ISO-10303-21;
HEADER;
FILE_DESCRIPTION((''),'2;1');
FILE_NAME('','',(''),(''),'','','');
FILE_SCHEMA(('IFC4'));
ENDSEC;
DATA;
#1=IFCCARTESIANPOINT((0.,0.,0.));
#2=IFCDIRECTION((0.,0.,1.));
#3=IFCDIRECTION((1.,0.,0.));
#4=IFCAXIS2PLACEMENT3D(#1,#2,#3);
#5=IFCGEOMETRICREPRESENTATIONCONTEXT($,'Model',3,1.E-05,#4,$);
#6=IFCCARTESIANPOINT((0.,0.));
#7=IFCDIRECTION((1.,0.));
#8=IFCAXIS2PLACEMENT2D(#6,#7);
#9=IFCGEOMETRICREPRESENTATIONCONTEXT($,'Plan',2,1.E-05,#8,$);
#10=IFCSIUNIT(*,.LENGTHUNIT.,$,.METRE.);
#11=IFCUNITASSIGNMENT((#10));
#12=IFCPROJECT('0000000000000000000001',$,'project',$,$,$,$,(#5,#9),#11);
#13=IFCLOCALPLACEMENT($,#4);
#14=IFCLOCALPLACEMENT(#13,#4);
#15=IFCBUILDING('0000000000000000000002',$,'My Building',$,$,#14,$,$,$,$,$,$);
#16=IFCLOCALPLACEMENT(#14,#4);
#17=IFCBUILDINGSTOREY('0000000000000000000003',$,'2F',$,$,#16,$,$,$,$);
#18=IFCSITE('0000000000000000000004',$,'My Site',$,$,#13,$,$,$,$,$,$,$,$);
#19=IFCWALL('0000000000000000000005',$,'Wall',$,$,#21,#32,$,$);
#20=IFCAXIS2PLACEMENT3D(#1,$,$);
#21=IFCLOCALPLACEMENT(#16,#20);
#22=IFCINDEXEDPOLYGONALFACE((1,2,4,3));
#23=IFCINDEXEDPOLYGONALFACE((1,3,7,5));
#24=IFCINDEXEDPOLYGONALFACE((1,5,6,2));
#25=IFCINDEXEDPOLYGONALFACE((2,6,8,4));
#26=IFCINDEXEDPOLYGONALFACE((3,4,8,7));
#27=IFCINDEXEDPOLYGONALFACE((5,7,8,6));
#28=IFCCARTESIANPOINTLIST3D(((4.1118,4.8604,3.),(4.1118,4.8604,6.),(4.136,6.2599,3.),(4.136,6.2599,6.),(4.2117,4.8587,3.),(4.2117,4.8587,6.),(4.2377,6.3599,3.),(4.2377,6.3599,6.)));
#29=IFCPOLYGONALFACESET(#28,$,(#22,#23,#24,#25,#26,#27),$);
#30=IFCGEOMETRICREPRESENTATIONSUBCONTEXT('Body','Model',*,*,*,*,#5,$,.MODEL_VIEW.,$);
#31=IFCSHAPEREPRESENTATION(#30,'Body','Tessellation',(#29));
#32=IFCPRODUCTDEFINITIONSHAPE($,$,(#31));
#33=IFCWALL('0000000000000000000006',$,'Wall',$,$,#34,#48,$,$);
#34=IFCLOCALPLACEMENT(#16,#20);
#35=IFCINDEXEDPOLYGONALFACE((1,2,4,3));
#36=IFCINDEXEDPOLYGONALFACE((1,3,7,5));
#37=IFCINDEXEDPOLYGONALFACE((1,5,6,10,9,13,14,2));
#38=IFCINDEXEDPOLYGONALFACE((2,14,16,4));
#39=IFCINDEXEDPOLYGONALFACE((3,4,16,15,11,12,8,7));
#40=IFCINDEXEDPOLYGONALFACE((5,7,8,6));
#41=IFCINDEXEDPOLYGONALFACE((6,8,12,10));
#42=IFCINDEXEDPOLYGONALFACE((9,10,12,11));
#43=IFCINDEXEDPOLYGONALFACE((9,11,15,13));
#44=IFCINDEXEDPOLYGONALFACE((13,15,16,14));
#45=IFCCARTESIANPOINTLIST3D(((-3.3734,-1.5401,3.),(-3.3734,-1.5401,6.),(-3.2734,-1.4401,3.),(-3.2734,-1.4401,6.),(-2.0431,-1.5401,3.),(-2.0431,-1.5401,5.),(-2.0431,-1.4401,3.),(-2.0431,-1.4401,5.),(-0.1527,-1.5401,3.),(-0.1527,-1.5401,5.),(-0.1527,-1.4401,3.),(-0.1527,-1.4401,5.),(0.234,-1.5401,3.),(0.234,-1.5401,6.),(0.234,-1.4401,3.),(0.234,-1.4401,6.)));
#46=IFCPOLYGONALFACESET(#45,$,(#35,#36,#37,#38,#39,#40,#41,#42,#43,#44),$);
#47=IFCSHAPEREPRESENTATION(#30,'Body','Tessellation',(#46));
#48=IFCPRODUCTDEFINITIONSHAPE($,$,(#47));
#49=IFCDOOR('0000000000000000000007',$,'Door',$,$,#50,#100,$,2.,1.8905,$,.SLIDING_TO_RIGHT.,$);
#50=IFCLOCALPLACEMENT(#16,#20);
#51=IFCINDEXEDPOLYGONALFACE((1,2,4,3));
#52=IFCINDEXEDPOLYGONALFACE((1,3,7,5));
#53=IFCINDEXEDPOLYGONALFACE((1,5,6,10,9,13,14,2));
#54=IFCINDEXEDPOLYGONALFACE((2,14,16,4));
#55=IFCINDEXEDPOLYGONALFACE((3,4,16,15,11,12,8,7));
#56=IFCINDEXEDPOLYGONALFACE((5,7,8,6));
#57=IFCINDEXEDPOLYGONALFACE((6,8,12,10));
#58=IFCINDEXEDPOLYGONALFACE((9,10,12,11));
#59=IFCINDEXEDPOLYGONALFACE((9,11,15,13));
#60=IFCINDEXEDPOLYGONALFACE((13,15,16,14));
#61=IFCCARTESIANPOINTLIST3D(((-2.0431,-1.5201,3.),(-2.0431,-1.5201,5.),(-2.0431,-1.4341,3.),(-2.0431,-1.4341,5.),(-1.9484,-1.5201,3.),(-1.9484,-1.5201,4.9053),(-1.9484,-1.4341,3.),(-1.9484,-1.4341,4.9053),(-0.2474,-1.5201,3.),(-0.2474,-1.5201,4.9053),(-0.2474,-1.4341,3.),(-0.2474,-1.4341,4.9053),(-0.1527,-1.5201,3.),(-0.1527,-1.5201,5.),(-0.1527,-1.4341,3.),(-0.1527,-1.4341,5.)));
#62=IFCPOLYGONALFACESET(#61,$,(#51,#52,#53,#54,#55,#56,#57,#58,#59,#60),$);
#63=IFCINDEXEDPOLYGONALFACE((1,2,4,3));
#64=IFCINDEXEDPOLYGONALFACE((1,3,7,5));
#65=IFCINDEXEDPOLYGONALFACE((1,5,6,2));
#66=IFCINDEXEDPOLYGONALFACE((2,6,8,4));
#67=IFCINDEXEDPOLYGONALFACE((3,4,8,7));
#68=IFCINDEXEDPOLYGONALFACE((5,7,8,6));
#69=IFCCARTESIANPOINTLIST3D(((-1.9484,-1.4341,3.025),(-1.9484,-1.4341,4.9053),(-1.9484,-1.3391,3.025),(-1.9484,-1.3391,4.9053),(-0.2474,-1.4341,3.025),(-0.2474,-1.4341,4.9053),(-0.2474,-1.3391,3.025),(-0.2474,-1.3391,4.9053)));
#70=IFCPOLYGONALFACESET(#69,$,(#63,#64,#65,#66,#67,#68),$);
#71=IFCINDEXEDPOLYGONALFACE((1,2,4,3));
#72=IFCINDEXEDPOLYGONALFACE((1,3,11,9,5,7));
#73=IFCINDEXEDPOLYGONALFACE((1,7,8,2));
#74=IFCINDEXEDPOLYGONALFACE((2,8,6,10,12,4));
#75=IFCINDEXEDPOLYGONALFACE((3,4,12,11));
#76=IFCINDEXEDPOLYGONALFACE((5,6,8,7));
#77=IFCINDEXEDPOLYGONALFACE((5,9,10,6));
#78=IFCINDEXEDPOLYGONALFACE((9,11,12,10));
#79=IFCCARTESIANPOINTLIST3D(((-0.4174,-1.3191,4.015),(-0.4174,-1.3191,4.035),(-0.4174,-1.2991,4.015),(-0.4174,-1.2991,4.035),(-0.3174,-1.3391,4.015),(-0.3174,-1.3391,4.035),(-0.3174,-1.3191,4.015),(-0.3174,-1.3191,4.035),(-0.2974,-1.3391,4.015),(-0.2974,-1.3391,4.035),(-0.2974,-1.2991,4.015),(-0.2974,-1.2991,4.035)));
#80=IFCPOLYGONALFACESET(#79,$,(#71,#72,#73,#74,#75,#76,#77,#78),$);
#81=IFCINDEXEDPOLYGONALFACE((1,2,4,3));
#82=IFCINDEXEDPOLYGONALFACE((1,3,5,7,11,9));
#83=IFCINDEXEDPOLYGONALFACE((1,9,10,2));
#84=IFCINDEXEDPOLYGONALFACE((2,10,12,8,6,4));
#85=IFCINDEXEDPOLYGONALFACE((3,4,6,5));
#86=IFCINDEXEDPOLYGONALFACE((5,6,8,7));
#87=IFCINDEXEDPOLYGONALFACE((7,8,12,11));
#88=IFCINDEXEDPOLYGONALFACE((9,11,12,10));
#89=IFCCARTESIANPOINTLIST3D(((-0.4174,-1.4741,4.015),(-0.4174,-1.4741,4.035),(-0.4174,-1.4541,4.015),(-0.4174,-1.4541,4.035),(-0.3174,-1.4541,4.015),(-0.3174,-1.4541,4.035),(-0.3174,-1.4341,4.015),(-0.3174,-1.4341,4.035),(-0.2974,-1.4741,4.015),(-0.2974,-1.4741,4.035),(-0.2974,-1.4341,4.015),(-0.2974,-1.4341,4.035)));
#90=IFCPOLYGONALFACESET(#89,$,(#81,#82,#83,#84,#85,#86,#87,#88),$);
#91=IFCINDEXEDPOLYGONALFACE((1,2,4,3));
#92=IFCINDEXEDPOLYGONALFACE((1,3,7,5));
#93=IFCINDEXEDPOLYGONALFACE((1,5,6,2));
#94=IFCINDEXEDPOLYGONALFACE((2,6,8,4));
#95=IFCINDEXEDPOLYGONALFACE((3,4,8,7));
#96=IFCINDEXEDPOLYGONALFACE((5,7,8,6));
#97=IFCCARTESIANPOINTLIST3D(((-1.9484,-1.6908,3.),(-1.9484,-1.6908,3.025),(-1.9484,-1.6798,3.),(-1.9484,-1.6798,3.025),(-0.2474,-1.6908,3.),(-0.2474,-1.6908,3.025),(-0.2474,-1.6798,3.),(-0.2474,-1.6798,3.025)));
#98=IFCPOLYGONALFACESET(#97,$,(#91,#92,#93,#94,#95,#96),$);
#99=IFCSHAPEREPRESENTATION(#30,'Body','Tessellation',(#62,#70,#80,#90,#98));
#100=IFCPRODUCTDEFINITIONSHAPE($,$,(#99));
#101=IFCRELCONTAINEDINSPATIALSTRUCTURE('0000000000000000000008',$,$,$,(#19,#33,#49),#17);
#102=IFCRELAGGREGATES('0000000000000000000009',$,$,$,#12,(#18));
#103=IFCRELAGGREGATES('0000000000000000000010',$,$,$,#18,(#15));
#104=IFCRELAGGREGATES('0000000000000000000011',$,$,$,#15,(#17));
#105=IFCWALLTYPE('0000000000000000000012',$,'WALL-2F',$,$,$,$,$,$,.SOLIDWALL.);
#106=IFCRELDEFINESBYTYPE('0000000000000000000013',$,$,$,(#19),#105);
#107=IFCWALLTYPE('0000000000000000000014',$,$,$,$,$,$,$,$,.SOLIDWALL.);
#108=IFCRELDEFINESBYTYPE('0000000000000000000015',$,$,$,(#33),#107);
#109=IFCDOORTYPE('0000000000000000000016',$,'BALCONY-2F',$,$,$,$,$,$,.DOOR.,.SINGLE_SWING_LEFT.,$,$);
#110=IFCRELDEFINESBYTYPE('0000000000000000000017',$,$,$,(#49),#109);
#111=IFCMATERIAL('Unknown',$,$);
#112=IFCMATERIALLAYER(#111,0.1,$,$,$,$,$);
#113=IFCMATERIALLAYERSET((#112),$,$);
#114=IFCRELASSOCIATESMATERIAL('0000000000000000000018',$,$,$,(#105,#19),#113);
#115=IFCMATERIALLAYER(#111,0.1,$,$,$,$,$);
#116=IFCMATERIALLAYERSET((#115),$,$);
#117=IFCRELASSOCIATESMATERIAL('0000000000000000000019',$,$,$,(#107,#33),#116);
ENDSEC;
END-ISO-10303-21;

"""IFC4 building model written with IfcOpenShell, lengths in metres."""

from ifc_helpers import new_model, entity, si_unit, frame, origin_with_axes, origin_2d_with_axis, place, context, subcontext, project, spatial, line, indexed_curve, outline, extrude, shape, source, transform, mapped, material, layer, layer_set, layer_usage, type_object, type_shapes, element, fill, save


model = new_model("IFC4")

# Units and contexts
model_context = context("Model", 3, precision=1e-05, world=origin_with_axes())
plan_context = context("Plan", 2, precision=1e-05, world=origin_2d_with_axis())
body_context_1 = subcontext(model_context, "Body", "Model", "MODEL_VIEW")
body_context_2 = subcontext(plan_context, "Body", "Plan", "PLAN_VIEW")
ifc_project = project(units=[si_unit("LENGTHUNIT", "METRE")], contexts=[model_context, plan_context])

# Site, building, storey
site_placement = place(None, origin_with_axes())
site = spatial("IfcSite", under=ifc_project, at=site_placement, Name="My Site")
building_placement = place(site_placement, origin_with_axes())
building = spatial("IfcBuilding", under=site, at=building_placement, Name="My Building")
storey_placement = place(building_placement, origin_with_axes())
storey = spatial("IfcBuildingStorey", under=building, at=storey_placement, Name="2F")

# Shared definitions
ifc_material = material(Name="Unknown")

# Shared definitions
ifc_layer_1 = layer(ifc_material, 0.1)
ifc_layer_set_1 = layer_set([ifc_layer_1])
wall_type_1 = type_object("IfcWallType", Name="WALL-2F", PredefinedType="SOLIDWALL", material=ifc_layer_set_1)

# Wall
ifc_layer_usage_1 = layer_usage(ifc_layer_set_1, "AXIS2", "POSITIVE", 0.0)
wall_1_placement = place(storey_placement, frame((4.2117, 4.8587, 3.0), z_axis=(0.0, 0.0, 1.0), x_axis=(0.0173, 0.99985, 0.0)))
element("IfcWall", 1, at=wall_1_placement, inside=storey, type_object=wall_type_1, material=ifc_layer_usage_1, Name="Wall", context=body_context_1, shape_type="SweptSolid", body=[
    extrude(outline(indexed_curve([(0.0, 0.0), (0.0, 0.1), (1.3997, 0.1), (1.5015, 0.0)], segments=[line(1, 2, 3, 4, 1)])), origin_with_axes(), (0.0, 0.0, 1.0), 3.0),
])

# Wall, opening, door
ifc_layer_2 = layer(ifc_material, 0.1)
ifc_layer_set_2 = layer_set([ifc_layer_2])
ifc_layer_usage_2 = layer_usage(ifc_layer_set_2, "AXIS2", "POSITIVE", 0.0)
wall_type_2 = type_object("IfcWallType", PredefinedType="SOLIDWALL", material=ifc_layer_set_2)
wall_2_placement = place(storey_placement, frame((-3.3734, -1.5401, 3.0), z_axis=(0.0, 0.0, 1.0), x_axis=(1.0, 0.0, 0.0)))
wall_2 = element("IfcWall", 2, at=wall_2_placement, inside=storey, type_object=wall_type_2, material=ifc_layer_usage_2, Name="Wall", context=body_context_1, shape_type="SweptSolid", body=[
    extrude(outline(indexed_curve([(0.0, 0.0), (0.1, 0.1), (3.6074, 0.1), (3.6074, 0.0)], segments=[line(1, 2, 3, 4, 1)])), origin_with_axes(), (0.0, 0.0, 1.0), 3.0),
])
shared_shape_1 = source(origin_with_axes(), body_context_1, "Body", "SweptSolid", [
    extrude(outline(indexed_curve([(0.0, 0.0), (1.8905, 0.0), (1.8905, 2.0), (0.0, 2.0)], segments=[line(1, 2, 3, 4, 1)])), frame((0.0, -0.6, 0.0), z_axis=(0.0, -1.0, 0.0), x_axis=(1.0, 0.0, 0.0)), (0.0, 0.0, -1.0), 1.2),
])
opening_1_placement = place(wall_2_placement, frame((1.3303, 0.0, 0.0), z_axis=(0.0, 0.0, 1.0), x_axis=(1.0, 0.0, 0.0)))
opening_1 = element("IfcOpeningElement", 3, at=opening_1_placement, cuts=wall_2, PredefinedType="OPENING", context=body_context_1, shape_type="MappedRepresentation", body=[
    mapped(shared_shape_1, transform((0.0, 0.0, 0.0), x_axis=(1.0, 0.0, 0.0), y_axis=(0.0, 1.0, 0.0), z_axis=(0.0, 0.0, 1.0), scale=1.0)),
])
door_type_1 = type_object("IfcDoorType", Name="BALCONY-2F", OperationType="SINGLE_SWING_LEFT", PredefinedType="DOOR")
shared_shape_2 = source(origin_with_axes(), body_context_1, "Body", "SweptSolid", [
    extrude(outline(indexed_curve([(0.0, 0.0), (0.0, 2.0), (1.8905, 2.0), (1.8905, 0.0), (1.7957, 0.0), (1.7957, 1.9053), (0.0947, 1.9053), (0.0947, 0.0)], segments=[line(1, 2, 3, 4, 5, 6, 7, 8, 1)])), frame((0.0, -0.0157, 0.0), z_axis=(0.0, -1.0, 0.0), x_axis=(1.0, 0.0, 0.0)), (0.0, 0.0, -1.0), 0.086),
    extrude(outline(indexed_curve([(0.0, 0.0), (1.701, 0.0), (1.701, 0.095), (0.0, 0.095)], segments=[line(1, 2, 3, 4, 1)])), frame((0.0947, -0.1107, 0.025), z_axis=(0.0, 0.0, 1.0), x_axis=(1.0, 0.0, 0.0)), (0.0, 0.0, 1.0), 1.8803),
    extrude(outline(indexed_curve([(0.0, 0.0), (0.0, -0.04), (0.12, -0.04), (0.12, -0.02), (0.02, -0.02), (0.02, 0.0)], segments=[line(1, 2, 3, 4, 5, 6, 1)])), frame((0.1447, -0.1107, 1.015), z_axis=(0.0, 0.0, 1.0), x_axis=(1.0, 0.0, 0.0)), (0.0, 0.0, 1.0), 0.02),
    extrude(outline(indexed_curve([(0.0, 0.0), (0.0, 0.04), (0.12, 0.04), (0.12, 0.02), (0.02, 0.02), (0.02, 0.0)], segments=[line(1, 2, 3, 4, 5, 6, 1)])), frame((0.1447, -0.0157, 1.015), z_axis=(0.0, 0.0, 1.0), x_axis=(1.0, 0.0, 0.0)), (0.0, 0.0, 1.0), 0.02),
    extrude(outline(indexed_curve([(0.0, 0.0), (1.701, 0.0), (1.701, 0.011), (0.0, 0.011)], segments=[line(1, 2, 3, 4, 1)])), frame((0.0947, 0.23, 0.0), z_axis=(0.0, 0.0, 1.0), x_axis=(1.0, 0.0, 0.0)), (0.0, 0.0, 1.0), 0.025),
])
shared_shape_3 = source(origin_with_axes(), body_context_2, "Body", "Curve2D", [
    entity("IfcIndexedPolyCurve", entity("IfcCartesianPointList2D", [[0.0, -0.0157], [0.0947, -0.0157], [0.0947, 0.0703], [0.0, 0.0703]]), [entity("IfcLineIndex", [1, 2, 3, 4, 1])]),
    entity("IfcIndexedPolyCurve", entity("IfcCartesianPointList2D", [[1.8905, -0.0157], [1.7957, -0.0157], [1.7957, 0.0703], [1.8905, 0.0703]]), [entity("IfcLineIndex", [1, 2, 3, 4, 1])]),
    entity("IfcIndexedPolyCurve", entity("IfcCartesianPointList2D", [[2.6462, -0.1107], [0.9452, -0.1107], [0.9452, -0.0157], [2.6462, -0.0157]]), [entity("IfcLineIndex", [1, 2, 3, 4, 1])]),
])
type_shapes(door_type_1, [shared_shape_2, shared_shape_3])
door_1_placement = place(opening_1_placement, frame((1.8905, 0.0903, 0.0), z_axis=(0.0, 0.0, 1.0), x_axis=(-1.0, 0.0, 0.0)))
door_1 = element("IfcDoor", 4, at=door_1_placement, inside=storey, type_object=door_type_1, Name="Door", OperationType="SLIDING_TO_RIGHT", OverallHeight=2.0, OverallWidth=1.8905, shapes=[
    shape(body_context_1, "Body", "MappedRepresentation", [mapped(shared_shape_2, transform((0.0, 0.0, 0.0), x_axis=(1.0, 0.0, 0.0), y_axis=(0.0, 1.0, 0.0), z_axis=(0.0, 0.0, 1.0), scale=1.0))]),
    shape(body_context_2, "Body", "MappedRepresentation", [mapped(shared_shape_3, transform((0.0, 0.0, 0.0), x_axis=(1.0, 0.0, 0.0), y_axis=(0.0, 1.0, 0.0), z_axis=(0.0, 0.0, 1.0), scale=1.0))]),
])
fill(opening_1, door_1)

save(model, "model.ifc")
